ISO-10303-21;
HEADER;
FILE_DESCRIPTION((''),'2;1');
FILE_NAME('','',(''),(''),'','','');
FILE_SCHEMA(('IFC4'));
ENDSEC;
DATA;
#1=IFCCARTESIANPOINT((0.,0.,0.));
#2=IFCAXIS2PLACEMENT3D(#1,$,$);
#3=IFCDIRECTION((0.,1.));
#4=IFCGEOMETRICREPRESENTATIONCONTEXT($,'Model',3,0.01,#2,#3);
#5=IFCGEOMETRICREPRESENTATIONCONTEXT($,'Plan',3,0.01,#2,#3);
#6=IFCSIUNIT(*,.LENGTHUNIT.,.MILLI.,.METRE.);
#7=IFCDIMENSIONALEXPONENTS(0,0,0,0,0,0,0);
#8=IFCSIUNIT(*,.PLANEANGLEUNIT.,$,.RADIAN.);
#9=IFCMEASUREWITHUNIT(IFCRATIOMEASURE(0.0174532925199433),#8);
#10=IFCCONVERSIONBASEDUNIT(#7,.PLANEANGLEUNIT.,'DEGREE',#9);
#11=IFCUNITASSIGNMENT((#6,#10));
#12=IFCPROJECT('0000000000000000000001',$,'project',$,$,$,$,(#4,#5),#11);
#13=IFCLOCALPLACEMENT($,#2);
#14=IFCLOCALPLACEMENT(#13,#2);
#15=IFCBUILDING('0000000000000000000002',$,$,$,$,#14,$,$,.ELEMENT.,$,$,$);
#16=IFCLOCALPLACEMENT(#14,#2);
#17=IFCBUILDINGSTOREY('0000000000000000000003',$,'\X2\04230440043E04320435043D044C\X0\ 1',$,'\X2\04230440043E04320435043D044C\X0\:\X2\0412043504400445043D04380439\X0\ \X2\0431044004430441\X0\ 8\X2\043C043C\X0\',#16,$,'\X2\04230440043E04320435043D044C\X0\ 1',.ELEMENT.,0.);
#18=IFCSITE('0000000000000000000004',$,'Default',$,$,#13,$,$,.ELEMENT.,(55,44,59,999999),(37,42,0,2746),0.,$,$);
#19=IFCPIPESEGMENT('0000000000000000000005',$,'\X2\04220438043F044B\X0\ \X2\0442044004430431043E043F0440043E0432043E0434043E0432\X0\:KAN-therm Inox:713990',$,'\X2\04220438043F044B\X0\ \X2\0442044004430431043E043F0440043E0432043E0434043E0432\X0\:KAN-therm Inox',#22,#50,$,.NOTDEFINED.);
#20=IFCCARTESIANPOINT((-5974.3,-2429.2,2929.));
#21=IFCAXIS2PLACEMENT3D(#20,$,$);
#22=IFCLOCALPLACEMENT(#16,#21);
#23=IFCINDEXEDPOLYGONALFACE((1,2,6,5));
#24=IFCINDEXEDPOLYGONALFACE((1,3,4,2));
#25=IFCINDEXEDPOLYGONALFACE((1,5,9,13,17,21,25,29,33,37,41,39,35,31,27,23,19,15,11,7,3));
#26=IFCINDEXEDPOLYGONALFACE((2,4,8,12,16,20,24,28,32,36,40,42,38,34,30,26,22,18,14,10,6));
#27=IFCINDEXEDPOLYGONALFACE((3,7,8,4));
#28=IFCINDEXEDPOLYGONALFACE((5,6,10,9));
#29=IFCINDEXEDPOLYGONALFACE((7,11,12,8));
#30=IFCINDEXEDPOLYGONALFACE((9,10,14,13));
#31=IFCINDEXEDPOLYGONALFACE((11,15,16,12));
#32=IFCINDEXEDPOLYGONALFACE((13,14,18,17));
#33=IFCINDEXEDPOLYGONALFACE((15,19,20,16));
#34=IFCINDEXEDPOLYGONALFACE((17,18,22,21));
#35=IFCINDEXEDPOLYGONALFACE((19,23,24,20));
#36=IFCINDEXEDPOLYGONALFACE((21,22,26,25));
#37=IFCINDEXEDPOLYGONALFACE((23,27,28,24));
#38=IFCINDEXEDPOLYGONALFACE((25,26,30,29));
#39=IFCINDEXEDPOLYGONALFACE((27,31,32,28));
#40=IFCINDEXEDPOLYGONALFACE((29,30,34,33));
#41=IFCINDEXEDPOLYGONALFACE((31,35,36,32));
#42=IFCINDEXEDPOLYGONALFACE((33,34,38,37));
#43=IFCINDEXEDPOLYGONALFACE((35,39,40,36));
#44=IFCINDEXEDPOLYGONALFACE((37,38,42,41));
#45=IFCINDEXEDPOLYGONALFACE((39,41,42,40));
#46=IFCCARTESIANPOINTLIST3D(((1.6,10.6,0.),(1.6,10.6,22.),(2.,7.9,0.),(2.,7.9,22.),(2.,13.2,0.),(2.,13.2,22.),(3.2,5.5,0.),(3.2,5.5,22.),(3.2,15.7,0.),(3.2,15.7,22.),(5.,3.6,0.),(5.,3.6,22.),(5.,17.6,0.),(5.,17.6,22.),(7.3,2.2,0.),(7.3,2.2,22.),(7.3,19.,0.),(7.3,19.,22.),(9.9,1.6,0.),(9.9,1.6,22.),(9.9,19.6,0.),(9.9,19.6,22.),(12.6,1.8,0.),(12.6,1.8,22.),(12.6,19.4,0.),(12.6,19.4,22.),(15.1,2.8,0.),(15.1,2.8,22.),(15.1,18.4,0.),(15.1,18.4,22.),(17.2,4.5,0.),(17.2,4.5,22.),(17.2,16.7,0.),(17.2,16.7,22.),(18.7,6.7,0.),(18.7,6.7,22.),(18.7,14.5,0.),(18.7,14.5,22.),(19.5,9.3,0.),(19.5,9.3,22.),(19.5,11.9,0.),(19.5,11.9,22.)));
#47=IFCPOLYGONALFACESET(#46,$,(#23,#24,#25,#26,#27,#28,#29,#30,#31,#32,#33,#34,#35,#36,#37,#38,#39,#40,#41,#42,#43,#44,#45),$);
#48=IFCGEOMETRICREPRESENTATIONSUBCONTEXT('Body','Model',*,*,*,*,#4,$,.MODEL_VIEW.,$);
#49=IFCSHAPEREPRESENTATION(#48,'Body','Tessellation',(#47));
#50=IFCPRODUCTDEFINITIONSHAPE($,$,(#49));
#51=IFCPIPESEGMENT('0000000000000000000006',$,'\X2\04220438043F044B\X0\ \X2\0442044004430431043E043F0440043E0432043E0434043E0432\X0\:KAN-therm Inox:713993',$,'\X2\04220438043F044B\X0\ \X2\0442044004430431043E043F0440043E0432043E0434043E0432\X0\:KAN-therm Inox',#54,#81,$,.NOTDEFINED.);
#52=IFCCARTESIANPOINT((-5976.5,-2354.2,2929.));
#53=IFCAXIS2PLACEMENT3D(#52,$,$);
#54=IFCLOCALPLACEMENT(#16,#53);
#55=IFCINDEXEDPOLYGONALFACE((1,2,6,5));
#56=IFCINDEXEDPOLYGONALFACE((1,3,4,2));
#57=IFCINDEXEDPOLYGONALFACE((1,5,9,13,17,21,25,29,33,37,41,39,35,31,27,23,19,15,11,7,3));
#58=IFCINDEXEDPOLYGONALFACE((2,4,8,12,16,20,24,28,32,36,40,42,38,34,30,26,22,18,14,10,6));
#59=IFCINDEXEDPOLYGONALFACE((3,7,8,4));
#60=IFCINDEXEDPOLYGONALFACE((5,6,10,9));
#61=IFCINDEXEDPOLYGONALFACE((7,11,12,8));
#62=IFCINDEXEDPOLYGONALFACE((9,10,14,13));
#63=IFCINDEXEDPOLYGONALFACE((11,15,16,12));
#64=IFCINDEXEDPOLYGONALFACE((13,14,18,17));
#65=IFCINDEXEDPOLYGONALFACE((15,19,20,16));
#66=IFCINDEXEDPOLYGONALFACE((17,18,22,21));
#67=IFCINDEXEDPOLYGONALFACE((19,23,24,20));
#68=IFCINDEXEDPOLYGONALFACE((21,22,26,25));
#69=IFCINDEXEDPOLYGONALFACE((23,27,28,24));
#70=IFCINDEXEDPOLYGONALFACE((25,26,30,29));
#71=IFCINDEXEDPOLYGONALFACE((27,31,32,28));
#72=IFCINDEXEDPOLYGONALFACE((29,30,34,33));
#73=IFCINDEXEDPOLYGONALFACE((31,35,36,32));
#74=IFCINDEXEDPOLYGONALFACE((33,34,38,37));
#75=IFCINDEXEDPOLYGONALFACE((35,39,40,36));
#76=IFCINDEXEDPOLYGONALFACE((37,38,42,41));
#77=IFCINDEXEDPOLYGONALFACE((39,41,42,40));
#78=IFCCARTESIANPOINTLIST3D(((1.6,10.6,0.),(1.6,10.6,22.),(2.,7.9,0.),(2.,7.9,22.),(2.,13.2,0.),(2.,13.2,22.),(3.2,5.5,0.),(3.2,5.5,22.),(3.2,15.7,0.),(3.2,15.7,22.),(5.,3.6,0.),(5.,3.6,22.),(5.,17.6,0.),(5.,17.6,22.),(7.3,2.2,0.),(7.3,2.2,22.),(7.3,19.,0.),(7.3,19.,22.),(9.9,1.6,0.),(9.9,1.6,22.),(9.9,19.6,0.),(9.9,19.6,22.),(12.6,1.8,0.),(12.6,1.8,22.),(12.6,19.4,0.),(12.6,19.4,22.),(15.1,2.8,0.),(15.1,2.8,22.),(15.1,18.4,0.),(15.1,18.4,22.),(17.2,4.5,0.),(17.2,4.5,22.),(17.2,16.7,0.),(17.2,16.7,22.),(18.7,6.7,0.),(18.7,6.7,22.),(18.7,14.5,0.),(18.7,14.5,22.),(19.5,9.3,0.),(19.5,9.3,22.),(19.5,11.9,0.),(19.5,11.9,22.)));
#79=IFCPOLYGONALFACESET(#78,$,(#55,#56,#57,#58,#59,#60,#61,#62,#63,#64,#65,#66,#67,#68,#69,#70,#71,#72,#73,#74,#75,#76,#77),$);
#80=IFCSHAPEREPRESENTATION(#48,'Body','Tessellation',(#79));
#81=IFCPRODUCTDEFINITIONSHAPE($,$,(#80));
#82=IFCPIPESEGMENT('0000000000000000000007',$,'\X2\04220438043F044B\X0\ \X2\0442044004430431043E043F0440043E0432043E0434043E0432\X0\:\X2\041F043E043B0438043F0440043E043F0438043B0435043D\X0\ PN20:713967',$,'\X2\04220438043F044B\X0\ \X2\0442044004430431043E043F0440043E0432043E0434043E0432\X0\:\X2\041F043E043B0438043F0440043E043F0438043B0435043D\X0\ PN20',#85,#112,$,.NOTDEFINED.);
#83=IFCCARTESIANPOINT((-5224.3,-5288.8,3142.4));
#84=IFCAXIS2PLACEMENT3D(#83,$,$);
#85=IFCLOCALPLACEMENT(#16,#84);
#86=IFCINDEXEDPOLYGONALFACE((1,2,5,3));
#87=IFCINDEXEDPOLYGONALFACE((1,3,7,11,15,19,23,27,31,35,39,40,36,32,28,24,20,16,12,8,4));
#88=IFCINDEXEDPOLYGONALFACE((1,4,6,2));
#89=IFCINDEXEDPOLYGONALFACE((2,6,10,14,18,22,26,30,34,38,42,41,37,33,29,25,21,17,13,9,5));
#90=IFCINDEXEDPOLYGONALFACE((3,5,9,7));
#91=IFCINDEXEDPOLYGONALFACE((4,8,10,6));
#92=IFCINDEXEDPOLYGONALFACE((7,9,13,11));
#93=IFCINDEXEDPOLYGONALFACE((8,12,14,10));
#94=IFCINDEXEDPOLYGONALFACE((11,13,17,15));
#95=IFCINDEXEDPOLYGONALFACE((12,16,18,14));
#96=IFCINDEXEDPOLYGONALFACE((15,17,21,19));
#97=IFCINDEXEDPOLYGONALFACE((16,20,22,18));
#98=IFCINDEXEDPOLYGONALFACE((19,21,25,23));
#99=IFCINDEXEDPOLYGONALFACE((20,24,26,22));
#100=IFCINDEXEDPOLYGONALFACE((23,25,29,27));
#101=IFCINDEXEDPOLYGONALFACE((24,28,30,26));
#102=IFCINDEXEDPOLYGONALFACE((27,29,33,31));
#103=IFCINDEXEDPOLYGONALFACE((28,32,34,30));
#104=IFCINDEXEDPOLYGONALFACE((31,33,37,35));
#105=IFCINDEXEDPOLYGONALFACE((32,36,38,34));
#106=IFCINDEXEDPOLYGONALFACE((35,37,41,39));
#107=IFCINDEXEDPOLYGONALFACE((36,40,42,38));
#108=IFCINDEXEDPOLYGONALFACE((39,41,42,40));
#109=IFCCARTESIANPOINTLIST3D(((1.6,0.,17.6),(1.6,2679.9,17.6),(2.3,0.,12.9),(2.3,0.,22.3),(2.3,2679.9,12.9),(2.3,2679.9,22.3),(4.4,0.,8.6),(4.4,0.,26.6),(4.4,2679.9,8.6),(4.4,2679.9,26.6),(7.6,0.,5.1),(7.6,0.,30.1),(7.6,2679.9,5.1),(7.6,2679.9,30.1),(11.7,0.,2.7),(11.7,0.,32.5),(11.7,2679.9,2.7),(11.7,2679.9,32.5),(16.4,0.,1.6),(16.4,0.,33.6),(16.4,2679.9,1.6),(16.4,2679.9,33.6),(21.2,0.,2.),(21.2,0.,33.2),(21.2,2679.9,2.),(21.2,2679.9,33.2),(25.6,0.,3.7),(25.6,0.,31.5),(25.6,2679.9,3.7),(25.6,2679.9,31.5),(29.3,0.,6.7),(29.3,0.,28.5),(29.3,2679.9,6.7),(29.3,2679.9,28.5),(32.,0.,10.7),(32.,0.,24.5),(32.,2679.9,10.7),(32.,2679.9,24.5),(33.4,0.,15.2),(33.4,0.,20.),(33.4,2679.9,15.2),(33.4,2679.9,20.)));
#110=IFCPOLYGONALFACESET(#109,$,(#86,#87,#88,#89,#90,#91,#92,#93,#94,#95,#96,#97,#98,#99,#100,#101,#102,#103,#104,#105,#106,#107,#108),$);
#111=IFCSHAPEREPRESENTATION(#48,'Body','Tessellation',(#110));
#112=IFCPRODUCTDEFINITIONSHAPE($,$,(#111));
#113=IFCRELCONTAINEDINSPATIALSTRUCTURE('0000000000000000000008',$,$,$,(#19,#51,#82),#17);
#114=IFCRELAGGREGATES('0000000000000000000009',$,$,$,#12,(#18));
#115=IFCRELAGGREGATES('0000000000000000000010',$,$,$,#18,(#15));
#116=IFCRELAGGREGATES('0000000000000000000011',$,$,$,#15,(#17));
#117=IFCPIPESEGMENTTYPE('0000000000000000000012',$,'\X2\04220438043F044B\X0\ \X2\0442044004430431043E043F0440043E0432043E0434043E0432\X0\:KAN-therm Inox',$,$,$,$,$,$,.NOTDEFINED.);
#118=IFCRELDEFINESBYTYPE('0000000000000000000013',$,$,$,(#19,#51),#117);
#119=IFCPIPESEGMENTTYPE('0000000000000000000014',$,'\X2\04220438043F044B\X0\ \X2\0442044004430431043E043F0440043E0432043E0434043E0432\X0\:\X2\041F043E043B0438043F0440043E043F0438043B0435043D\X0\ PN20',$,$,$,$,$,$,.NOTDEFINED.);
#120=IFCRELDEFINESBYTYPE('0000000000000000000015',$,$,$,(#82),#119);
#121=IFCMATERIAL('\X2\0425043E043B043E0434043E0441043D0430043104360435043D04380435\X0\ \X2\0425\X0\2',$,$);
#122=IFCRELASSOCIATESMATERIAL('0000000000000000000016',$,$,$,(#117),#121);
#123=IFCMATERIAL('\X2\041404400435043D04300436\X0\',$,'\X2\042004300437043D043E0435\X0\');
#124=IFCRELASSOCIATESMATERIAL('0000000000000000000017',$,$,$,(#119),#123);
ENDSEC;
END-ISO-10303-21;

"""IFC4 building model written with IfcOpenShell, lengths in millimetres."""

from ifc_helpers import new_model, entity, si_unit, converted_unit, direction, frame, frame_2d, origin, origin_2d_with_axis, place, context, subcontext, project, spatial, circle, extrude, material, type_object, element, save


model = new_model("IFC4")

# Units and contexts
model_context = context("Model", 3, precision=0.01, world=origin(), true_north=direction((0.0, 1.0)))
plan_context = context("Plan", 3, precision=0.01, world=origin(), true_north=direction((0.0, 1.0)))
body_context = subcontext(model_context, "Body", "Model", "MODEL_VIEW")
ifc_project = project(units=[si_unit("LENGTHUNIT", "METRE", prefix="MILLI"), converted_unit("PLANEANGLEUNIT", "DEGREE", entity("IfcRatioMeasure", 0.0174532925199433), si_unit("PLANEANGLEUNIT", "RADIAN"), dimensions=[0, 0, 0, 0, 0, 0, 0])], contexts=[model_context, plan_context])

# Site, building, storey
site_placement = place(None, origin())
site = spatial("IfcSite", under=ifc_project, at=site_placement, Name="Default", CompositionType="ELEMENT", RefLatitude=(55, 44, 59, 999999), RefLongitude=(37, 42, 0, 2746), RefElevation=0.0)
building_placement = place(site_placement, origin())
building = spatial("IfcBuilding", under=site, at=building_placement, CompositionType="ELEMENT")
storey_placement = place(building_placement, origin())
storey = spatial("IfcBuildingStorey", under=building, at=storey_placement, Name="Уровень 1", ObjectType="Уровень:Верхний брус 8мм", LongName="Уровень 1", CompositionType="ELEMENT", Elevation=0.0)

# Shared definitions
ifc_material_1 = material(Name="Холодоснабжение Х2")

# Shared definitions
pipe_segment_type_1 = type_object("IfcPipeSegmentType", Name="Типы трубопроводов:KAN-therm Inox", PredefinedType="NOTDEFINED", material=ifc_material_1)

# Pipe segments
for number, where, name in (
    (1, (-5974.3, -2429.2, 2929.0), "Типы трубопроводов:KAN-therm Inox:713990"),
    (2, (-5976.5, -2354.2, 2929.0), "Типы трубопроводов:KAN-therm Inox:713993"),
):
    element("IfcPipeSegment", number, at=place(storey_placement, frame(where)), inside=storey, type_object=pipe_segment_type_1, Name=name, ObjectType="Типы трубопроводов:KAN-therm Inox", PredefinedType="NOTDEFINED", context=body_context, shape_type="SweptSolid", body=[
        extrude(circle(Radius=9.0, at=origin_2d_with_axis()), frame((10.6, 10.6, 0.0), z_axis=(0.0, 0.0, 1.0), x_axis=(-1.0, 0.0, 0.0)), (0.0, 0.0, 1.0), 22.0),
    ])
ifc_material_2 = material(Name="Дренаж", Category="Разное")
pipe_segment_type_2 = type_object("IfcPipeSegmentType", Name="Типы трубопроводов:Полипропилен PN20", PredefinedType="NOTDEFINED", material=ifc_material_2)
pipe_segment_1_placement = place(storey_placement, frame((-5224.3, -5288.8, 3142.4)))
element("IfcPipeSegment", 3, at=pipe_segment_1_placement, inside=storey, type_object=pipe_segment_type_2, Name="Типы трубопроводов:Полипропилен PN20:713967", ObjectType="Типы трубопроводов:Полипропилен PN20", PredefinedType="NOTDEFINED", context=body_context, shape_type="SweptSolid", body=[
    extrude(circle(Radius=16.0, at=frame_2d((0.0, 0.0), x_axis=(1.0, 0.0))), frame((17.6, 0.0, 17.6), z_axis=(0.0, 1.0, 0.0), x_axis=(-1.0, 0.0, 0.0)), (0.0, 0.0, 1.0), 2679.9),
])

save(model, "model.ifc")
